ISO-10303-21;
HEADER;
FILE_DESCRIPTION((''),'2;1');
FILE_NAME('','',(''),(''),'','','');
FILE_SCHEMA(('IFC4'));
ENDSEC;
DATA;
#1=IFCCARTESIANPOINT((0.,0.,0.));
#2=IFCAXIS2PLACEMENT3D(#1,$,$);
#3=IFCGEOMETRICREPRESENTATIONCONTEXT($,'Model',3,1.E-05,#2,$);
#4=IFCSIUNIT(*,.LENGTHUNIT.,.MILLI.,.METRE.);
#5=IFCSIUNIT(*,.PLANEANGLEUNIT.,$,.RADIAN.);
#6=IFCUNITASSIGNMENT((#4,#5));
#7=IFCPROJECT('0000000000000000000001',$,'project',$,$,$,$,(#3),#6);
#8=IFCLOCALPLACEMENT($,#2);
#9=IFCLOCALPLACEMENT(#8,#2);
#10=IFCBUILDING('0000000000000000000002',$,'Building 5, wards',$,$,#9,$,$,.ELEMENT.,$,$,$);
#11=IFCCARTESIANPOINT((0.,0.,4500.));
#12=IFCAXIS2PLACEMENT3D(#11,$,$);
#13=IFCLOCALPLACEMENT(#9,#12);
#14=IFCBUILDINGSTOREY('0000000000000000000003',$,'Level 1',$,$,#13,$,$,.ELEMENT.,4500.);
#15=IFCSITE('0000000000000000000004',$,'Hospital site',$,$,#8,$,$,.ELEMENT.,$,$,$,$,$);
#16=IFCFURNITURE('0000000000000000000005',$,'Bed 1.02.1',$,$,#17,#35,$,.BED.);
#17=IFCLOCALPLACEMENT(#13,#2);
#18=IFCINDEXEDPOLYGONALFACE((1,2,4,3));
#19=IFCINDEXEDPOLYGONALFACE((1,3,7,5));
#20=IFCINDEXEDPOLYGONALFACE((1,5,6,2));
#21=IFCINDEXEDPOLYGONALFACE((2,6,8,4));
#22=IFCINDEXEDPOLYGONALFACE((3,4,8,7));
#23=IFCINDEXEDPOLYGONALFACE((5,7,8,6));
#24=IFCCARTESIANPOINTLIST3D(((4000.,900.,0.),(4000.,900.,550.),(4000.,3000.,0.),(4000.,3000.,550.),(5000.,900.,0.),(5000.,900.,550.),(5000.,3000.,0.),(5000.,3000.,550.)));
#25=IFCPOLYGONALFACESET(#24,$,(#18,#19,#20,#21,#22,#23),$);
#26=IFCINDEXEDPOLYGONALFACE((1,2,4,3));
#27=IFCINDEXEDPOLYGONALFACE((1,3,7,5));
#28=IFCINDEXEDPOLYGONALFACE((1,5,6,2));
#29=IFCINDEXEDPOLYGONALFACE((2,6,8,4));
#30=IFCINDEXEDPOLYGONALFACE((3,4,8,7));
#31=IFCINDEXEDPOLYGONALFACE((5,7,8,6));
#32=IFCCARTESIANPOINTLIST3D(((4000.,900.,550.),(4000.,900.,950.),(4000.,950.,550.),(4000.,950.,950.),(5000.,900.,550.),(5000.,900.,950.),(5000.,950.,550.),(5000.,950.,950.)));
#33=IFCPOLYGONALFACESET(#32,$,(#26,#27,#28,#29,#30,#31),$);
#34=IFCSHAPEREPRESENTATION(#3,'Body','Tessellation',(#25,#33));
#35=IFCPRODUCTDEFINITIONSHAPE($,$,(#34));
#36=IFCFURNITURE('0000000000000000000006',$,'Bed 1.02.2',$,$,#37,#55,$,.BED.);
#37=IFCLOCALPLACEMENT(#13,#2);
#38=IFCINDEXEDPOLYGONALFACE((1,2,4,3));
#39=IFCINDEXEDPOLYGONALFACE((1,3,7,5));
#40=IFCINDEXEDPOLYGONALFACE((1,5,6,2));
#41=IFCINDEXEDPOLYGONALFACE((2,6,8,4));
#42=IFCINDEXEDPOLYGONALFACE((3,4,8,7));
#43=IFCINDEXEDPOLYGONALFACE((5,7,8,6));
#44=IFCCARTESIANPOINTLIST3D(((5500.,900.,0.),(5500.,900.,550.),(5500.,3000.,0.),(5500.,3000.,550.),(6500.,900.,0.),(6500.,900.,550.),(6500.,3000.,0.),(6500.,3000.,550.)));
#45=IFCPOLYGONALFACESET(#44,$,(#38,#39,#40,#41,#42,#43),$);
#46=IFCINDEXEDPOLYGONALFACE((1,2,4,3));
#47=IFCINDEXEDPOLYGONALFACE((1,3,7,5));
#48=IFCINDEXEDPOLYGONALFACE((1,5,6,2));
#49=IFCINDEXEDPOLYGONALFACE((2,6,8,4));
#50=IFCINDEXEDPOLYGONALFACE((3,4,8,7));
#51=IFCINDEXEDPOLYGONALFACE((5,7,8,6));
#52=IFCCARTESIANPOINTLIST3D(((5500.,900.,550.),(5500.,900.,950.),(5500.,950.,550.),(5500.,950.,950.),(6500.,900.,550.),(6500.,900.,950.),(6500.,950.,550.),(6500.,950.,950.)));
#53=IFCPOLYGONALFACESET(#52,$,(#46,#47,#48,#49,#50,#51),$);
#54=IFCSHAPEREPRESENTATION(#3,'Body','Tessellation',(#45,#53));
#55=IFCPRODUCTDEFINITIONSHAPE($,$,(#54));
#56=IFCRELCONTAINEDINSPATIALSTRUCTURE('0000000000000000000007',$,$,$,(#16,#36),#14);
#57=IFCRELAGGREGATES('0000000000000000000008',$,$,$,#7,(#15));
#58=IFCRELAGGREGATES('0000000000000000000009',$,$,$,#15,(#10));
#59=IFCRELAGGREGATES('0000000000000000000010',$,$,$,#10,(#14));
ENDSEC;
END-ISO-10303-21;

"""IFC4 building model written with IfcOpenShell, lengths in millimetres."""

from ifc_helpers import new_model, si_unit, frame, frame_2d, origin, place, context, project, spatial, rectangle, extrude, element, save


model = new_model("IFC4")

# Units and contexts
model_context = context("Model", 3, precision=1e-05, world=origin())
ifc_project = project(units=[si_unit("LENGTHUNIT", "METRE", prefix="MILLI"), si_unit("PLANEANGLEUNIT", "RADIAN")], contexts=[model_context])

# Site, building, storey
site_placement = place(None, origin())
site = spatial("IfcSite", under=ifc_project, at=site_placement, Name="Hospital site", CompositionType="ELEMENT")
building_placement = place(site_placement, origin())
building = spatial("IfcBuilding", under=site, at=building_placement, Name="Building 5, wards", CompositionType="ELEMENT")
storey_placement = place(building_placement, frame((0.0, 0.0, 4500.0)))
storey = spatial("IfcBuildingStorey", under=building, at=storey_placement, Name="Level 1", CompositionType="ELEMENT", Elevation=4500.0)

# Furniture
for number, where, name in (
    (1, (4000.0, 900.0, 0.0), "Bed 1.02.1"),
    (2, (5500.0, 900.0, 0.0), "Bed 1.02.2"),
):
    element("IfcFurniture", number, at=place(storey_placement, frame(where)), inside=storey, Name=name, PredefinedType="BED", context=model_context, shape_type="SweptSolid", body=[
        extrude(rectangle(XDim=1000.0, YDim=2100.0, at=frame_2d((500.0, 1050.0))), origin(), (0.0, 0.0, 1.0), 550.0),
        extrude(rectangle(XDim=1000.0, YDim=50.0, at=frame_2d((500.0, 25.0))), frame((0.0, 0.0, 550.0)), (0.0, 0.0, 1.0), 400.0),
    ])

save(model, "model.ifc")
